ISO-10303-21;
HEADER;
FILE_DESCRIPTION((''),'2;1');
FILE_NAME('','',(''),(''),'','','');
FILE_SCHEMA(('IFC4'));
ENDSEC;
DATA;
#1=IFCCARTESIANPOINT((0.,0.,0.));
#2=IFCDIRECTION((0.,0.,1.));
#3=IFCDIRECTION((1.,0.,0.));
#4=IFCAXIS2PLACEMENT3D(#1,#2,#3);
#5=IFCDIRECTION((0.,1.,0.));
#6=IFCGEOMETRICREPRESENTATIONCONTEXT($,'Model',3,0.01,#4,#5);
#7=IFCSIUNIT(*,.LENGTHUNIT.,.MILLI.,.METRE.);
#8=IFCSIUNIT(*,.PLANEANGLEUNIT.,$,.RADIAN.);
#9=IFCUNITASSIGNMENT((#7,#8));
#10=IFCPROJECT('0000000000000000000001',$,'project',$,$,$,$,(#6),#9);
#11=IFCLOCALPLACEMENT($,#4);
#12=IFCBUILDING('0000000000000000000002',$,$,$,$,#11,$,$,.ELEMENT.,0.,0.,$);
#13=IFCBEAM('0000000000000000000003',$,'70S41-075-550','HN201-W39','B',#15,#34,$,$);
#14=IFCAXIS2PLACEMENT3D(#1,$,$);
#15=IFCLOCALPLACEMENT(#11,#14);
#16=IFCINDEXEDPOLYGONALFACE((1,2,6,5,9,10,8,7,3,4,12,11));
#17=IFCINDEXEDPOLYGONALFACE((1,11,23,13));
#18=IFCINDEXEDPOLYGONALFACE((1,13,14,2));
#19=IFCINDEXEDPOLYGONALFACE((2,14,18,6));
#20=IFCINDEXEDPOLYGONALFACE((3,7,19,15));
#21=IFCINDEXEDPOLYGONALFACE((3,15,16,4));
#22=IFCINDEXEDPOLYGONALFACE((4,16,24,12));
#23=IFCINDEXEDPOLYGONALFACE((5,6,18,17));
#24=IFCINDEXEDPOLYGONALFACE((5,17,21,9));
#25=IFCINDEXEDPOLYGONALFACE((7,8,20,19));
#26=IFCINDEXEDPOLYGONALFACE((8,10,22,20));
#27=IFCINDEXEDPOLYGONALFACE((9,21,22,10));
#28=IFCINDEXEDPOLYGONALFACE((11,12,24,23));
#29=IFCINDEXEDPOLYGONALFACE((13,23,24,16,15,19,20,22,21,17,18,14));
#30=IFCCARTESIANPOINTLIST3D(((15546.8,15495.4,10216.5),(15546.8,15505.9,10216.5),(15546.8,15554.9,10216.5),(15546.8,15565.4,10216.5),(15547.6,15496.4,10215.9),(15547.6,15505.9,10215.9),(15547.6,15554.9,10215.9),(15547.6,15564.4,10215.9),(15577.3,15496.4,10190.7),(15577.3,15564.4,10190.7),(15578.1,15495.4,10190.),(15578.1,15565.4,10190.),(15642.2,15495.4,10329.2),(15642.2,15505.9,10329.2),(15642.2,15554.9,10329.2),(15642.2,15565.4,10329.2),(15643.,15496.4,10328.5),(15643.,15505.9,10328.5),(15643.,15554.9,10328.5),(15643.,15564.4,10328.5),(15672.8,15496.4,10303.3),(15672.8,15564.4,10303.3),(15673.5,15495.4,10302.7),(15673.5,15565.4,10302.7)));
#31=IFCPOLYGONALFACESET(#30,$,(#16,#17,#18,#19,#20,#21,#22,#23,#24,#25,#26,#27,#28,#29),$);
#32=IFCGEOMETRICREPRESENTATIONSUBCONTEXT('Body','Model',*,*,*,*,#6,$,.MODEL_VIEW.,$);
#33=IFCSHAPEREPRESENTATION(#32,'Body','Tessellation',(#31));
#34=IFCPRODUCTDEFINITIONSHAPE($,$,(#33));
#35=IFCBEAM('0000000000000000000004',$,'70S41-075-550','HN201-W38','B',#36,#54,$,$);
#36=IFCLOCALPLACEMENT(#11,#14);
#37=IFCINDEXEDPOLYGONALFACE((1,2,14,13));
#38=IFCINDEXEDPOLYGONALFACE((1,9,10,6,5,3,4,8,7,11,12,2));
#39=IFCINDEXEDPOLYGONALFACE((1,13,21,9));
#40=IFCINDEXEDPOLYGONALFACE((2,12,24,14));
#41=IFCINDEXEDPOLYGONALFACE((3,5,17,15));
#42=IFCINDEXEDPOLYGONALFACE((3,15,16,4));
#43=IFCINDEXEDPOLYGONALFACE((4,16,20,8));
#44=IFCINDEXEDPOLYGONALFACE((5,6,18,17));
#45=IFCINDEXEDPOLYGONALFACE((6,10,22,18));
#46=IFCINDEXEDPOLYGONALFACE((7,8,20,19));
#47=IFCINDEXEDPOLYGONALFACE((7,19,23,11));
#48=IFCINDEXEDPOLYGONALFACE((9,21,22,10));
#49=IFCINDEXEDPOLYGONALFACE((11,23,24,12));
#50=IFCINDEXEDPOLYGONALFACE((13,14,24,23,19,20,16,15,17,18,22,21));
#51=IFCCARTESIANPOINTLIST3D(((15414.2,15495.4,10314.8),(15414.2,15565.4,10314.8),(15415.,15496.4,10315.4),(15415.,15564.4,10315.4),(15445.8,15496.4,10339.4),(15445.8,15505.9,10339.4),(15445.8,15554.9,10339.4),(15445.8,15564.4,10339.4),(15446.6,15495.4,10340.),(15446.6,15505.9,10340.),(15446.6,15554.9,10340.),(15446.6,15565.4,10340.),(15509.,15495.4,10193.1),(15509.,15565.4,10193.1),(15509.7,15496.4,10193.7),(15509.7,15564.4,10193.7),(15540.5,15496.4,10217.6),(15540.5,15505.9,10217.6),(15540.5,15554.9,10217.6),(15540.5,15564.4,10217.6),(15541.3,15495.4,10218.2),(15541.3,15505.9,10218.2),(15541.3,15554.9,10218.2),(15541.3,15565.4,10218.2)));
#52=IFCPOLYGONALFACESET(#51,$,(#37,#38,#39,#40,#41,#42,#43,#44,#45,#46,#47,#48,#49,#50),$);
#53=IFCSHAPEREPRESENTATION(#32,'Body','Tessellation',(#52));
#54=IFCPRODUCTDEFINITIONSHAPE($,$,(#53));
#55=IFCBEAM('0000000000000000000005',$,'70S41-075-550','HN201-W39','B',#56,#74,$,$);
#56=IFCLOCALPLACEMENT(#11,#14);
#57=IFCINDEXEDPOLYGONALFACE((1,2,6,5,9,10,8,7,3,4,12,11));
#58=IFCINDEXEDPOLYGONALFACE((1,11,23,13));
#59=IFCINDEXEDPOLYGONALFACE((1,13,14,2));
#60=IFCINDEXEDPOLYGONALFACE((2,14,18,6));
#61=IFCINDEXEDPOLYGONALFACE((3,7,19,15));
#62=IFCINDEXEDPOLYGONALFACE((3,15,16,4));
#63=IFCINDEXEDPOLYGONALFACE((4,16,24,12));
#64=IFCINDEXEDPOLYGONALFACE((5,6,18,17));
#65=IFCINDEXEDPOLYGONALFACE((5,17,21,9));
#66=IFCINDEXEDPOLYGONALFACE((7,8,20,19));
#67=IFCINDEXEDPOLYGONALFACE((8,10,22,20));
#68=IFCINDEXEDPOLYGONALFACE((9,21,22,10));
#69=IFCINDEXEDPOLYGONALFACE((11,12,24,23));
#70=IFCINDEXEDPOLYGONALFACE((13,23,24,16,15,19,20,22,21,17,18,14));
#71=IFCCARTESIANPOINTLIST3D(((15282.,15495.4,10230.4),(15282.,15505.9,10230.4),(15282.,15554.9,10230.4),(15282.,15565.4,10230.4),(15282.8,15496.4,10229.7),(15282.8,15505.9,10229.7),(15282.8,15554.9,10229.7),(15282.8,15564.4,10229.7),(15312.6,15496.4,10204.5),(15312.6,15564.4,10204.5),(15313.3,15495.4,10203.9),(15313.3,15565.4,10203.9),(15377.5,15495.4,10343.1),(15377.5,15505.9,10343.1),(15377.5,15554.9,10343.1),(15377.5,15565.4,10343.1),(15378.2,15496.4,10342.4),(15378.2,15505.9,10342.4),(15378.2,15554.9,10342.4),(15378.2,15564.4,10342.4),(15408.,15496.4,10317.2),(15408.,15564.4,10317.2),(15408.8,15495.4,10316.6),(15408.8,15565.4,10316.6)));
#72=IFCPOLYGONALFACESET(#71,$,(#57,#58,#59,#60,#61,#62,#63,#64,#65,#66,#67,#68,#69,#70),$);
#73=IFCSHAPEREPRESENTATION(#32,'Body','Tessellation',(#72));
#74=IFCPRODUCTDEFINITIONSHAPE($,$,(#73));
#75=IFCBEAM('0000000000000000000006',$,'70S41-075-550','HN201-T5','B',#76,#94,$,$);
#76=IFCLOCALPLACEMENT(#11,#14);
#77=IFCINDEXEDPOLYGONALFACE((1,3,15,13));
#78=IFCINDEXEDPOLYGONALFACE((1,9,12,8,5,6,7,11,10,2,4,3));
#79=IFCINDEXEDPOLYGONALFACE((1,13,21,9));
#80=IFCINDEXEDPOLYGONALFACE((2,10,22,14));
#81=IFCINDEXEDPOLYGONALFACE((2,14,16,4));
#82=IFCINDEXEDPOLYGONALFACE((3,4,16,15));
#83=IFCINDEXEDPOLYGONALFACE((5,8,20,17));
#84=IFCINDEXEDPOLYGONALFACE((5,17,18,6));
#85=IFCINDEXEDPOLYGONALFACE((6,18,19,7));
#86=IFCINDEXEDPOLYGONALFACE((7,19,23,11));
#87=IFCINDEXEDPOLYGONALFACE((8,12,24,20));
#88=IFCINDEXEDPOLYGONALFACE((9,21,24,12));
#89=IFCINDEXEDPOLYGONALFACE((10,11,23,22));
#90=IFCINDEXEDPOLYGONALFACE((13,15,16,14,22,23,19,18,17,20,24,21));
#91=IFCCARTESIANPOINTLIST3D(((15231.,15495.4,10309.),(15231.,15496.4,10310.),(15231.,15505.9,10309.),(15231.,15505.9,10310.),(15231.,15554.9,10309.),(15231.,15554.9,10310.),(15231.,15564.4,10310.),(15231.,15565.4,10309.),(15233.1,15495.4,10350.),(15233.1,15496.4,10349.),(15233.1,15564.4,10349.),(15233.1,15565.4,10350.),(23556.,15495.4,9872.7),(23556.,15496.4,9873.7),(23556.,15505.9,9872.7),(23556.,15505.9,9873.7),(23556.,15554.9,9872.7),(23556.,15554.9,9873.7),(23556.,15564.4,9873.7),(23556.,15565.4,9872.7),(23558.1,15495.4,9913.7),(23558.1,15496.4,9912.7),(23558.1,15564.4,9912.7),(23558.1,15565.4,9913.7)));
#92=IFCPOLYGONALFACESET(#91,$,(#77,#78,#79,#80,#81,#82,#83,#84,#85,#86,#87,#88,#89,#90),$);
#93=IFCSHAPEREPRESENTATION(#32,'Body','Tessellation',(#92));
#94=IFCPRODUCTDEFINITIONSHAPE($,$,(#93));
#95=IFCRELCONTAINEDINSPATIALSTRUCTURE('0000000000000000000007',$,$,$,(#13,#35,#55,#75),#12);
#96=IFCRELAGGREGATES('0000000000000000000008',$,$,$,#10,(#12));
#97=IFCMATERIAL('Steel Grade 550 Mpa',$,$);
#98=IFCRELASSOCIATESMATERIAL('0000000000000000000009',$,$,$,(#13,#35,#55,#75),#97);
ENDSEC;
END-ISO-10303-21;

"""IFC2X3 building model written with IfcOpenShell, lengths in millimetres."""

from ifc_helpers import new_model, si_unit, direction, frame, origin, origin_with_axes, origin_2d_with_axis, place, context, subcontext, project, spatial, c_section, extrude, source, transform, mapped, material, element, save


model = new_model("IFC2X3")

# Units and contexts
model_context = context("Model", 3, precision=0.01, world=origin_with_axes(), true_north=direction((0.0, 1.0, 0.0)))
body_context = subcontext(model_context, "Body", "Model", "MODEL_VIEW")
ifc_project = project(units=[si_unit("LENGTHUNIT", "METRE", prefix="MILLI"), si_unit("PLANEANGLEUNIT", "RADIAN")], contexts=[model_context])

# Building
building_placement = place(None, origin_with_axes())
building = spatial("IfcBuilding", under=ifc_project, at=building_placement, CompositionType="ELEMENT", ElevationOfRefHeight=0.0, ElevationOfTerrain=0.0)

# Shared definitions
ifc_material = material(Name="Steel Grade 550 Mpa")

# Beams
shared_shape_1 = source(origin(), body_context, "Body", "SweptSolid", [
    extrude(c_section(Depth=70.0, Width=41.0, WallThickness=1.0, Girth=10.5, at=origin_2d_with_axis()), origin_with_axes(), (0.0, 0.0, 1.0), 147.6),
])
beam_1_placement = place(None, frame((15657.9, 15530.4, 10315.9), z_axis=(-0.646275, 0.0, -0.763105), x_axis=(-0.763105, 0.0, 0.646275)))
element("IfcBeam", 1, at=beam_1_placement, inside=building, material=ifc_material, Name="70S41-075-550", Description="HN201-W39", ObjectType="B", context=body_context, shape_type="MappedRepresentation", body=[
    mapped(shared_shape_1, transform((0.0, 0.0, 0.0), scale=1.0)),
])
shared_shape_2 = source(origin(), body_context, "Body", "SweptSolid", [
    extrude(c_section(Depth=70.0, Width=41.0, WallThickness=1.0, Girth=10.5, at=origin_2d_with_axis()), origin_with_axes(), (0.0, 0.0, 1.0), 154.3),
])
beam_2_placement = place(None, frame((15525.1, 15530.4, 10205.7), z_axis=(-0.613981, 0.0, 0.789321), x_axis=(0.789321, 0.0, 0.613981)))
element("IfcBeam", 2, at=beam_2_placement, inside=building, material=ifc_material, Name="70S41-075-550", Description="HN201-W38", ObjectType="B", context=body_context, shape_type="MappedRepresentation", body=[
    mapped(shared_shape_2, transform((0.0, 0.0, 0.0), scale=1.0)),
])
shared_shape_3 = source(origin(), body_context, "Body", "SweptSolid", [
    extrude(c_section(Depth=70.0, Width=41.0, WallThickness=1.0, Girth=10.5, at=origin_2d_with_axis()), origin_with_axes(), (0.0, 0.0, 1.0), 147.6),
])
beam_3_placement = place(None, frame((15393.1, 15530.4, 10329.8), z_axis=(-0.646275, 0.0, -0.763105), x_axis=(-0.763105, 0.0, 0.646275)))
element("IfcBeam", 3, at=beam_3_placement, inside=building, material=ifc_material, Name="70S41-075-550", Description="HN201-W39", ObjectType="B", context=body_context, shape_type="MappedRepresentation", body=[
    mapped(shared_shape_3, transform((0.0, 0.0, 0.0), scale=1.0)),
])
shared_shape_4 = source(origin(), body_context, "Body", "SweptSolid", [
    extrude(c_section(Depth=70.0, Width=41.0, WallThickness=1.0, Girth=10.5, at=origin_2d_with_axis()), origin_with_axes(), (0.0, 0.0, 1.0), 8336.4),
])
beam_4_placement = place(None, frame((15232.0, 15530.4, 10329.5), z_axis=(0.99863, 0.0, -0.052336), x_axis=(-0.052336, 0.0, -0.99863)))
element("IfcBeam", 4, at=beam_4_placement, inside=building, material=ifc_material, Name="70S41-075-550", Description="HN201-T5", ObjectType="B", context=body_context, shape_type="MappedRepresentation", body=[
    mapped(shared_shape_4, transform((0.0, 0.0, 0.0), scale=1.0)),
])

save(model, "model.ifc")
